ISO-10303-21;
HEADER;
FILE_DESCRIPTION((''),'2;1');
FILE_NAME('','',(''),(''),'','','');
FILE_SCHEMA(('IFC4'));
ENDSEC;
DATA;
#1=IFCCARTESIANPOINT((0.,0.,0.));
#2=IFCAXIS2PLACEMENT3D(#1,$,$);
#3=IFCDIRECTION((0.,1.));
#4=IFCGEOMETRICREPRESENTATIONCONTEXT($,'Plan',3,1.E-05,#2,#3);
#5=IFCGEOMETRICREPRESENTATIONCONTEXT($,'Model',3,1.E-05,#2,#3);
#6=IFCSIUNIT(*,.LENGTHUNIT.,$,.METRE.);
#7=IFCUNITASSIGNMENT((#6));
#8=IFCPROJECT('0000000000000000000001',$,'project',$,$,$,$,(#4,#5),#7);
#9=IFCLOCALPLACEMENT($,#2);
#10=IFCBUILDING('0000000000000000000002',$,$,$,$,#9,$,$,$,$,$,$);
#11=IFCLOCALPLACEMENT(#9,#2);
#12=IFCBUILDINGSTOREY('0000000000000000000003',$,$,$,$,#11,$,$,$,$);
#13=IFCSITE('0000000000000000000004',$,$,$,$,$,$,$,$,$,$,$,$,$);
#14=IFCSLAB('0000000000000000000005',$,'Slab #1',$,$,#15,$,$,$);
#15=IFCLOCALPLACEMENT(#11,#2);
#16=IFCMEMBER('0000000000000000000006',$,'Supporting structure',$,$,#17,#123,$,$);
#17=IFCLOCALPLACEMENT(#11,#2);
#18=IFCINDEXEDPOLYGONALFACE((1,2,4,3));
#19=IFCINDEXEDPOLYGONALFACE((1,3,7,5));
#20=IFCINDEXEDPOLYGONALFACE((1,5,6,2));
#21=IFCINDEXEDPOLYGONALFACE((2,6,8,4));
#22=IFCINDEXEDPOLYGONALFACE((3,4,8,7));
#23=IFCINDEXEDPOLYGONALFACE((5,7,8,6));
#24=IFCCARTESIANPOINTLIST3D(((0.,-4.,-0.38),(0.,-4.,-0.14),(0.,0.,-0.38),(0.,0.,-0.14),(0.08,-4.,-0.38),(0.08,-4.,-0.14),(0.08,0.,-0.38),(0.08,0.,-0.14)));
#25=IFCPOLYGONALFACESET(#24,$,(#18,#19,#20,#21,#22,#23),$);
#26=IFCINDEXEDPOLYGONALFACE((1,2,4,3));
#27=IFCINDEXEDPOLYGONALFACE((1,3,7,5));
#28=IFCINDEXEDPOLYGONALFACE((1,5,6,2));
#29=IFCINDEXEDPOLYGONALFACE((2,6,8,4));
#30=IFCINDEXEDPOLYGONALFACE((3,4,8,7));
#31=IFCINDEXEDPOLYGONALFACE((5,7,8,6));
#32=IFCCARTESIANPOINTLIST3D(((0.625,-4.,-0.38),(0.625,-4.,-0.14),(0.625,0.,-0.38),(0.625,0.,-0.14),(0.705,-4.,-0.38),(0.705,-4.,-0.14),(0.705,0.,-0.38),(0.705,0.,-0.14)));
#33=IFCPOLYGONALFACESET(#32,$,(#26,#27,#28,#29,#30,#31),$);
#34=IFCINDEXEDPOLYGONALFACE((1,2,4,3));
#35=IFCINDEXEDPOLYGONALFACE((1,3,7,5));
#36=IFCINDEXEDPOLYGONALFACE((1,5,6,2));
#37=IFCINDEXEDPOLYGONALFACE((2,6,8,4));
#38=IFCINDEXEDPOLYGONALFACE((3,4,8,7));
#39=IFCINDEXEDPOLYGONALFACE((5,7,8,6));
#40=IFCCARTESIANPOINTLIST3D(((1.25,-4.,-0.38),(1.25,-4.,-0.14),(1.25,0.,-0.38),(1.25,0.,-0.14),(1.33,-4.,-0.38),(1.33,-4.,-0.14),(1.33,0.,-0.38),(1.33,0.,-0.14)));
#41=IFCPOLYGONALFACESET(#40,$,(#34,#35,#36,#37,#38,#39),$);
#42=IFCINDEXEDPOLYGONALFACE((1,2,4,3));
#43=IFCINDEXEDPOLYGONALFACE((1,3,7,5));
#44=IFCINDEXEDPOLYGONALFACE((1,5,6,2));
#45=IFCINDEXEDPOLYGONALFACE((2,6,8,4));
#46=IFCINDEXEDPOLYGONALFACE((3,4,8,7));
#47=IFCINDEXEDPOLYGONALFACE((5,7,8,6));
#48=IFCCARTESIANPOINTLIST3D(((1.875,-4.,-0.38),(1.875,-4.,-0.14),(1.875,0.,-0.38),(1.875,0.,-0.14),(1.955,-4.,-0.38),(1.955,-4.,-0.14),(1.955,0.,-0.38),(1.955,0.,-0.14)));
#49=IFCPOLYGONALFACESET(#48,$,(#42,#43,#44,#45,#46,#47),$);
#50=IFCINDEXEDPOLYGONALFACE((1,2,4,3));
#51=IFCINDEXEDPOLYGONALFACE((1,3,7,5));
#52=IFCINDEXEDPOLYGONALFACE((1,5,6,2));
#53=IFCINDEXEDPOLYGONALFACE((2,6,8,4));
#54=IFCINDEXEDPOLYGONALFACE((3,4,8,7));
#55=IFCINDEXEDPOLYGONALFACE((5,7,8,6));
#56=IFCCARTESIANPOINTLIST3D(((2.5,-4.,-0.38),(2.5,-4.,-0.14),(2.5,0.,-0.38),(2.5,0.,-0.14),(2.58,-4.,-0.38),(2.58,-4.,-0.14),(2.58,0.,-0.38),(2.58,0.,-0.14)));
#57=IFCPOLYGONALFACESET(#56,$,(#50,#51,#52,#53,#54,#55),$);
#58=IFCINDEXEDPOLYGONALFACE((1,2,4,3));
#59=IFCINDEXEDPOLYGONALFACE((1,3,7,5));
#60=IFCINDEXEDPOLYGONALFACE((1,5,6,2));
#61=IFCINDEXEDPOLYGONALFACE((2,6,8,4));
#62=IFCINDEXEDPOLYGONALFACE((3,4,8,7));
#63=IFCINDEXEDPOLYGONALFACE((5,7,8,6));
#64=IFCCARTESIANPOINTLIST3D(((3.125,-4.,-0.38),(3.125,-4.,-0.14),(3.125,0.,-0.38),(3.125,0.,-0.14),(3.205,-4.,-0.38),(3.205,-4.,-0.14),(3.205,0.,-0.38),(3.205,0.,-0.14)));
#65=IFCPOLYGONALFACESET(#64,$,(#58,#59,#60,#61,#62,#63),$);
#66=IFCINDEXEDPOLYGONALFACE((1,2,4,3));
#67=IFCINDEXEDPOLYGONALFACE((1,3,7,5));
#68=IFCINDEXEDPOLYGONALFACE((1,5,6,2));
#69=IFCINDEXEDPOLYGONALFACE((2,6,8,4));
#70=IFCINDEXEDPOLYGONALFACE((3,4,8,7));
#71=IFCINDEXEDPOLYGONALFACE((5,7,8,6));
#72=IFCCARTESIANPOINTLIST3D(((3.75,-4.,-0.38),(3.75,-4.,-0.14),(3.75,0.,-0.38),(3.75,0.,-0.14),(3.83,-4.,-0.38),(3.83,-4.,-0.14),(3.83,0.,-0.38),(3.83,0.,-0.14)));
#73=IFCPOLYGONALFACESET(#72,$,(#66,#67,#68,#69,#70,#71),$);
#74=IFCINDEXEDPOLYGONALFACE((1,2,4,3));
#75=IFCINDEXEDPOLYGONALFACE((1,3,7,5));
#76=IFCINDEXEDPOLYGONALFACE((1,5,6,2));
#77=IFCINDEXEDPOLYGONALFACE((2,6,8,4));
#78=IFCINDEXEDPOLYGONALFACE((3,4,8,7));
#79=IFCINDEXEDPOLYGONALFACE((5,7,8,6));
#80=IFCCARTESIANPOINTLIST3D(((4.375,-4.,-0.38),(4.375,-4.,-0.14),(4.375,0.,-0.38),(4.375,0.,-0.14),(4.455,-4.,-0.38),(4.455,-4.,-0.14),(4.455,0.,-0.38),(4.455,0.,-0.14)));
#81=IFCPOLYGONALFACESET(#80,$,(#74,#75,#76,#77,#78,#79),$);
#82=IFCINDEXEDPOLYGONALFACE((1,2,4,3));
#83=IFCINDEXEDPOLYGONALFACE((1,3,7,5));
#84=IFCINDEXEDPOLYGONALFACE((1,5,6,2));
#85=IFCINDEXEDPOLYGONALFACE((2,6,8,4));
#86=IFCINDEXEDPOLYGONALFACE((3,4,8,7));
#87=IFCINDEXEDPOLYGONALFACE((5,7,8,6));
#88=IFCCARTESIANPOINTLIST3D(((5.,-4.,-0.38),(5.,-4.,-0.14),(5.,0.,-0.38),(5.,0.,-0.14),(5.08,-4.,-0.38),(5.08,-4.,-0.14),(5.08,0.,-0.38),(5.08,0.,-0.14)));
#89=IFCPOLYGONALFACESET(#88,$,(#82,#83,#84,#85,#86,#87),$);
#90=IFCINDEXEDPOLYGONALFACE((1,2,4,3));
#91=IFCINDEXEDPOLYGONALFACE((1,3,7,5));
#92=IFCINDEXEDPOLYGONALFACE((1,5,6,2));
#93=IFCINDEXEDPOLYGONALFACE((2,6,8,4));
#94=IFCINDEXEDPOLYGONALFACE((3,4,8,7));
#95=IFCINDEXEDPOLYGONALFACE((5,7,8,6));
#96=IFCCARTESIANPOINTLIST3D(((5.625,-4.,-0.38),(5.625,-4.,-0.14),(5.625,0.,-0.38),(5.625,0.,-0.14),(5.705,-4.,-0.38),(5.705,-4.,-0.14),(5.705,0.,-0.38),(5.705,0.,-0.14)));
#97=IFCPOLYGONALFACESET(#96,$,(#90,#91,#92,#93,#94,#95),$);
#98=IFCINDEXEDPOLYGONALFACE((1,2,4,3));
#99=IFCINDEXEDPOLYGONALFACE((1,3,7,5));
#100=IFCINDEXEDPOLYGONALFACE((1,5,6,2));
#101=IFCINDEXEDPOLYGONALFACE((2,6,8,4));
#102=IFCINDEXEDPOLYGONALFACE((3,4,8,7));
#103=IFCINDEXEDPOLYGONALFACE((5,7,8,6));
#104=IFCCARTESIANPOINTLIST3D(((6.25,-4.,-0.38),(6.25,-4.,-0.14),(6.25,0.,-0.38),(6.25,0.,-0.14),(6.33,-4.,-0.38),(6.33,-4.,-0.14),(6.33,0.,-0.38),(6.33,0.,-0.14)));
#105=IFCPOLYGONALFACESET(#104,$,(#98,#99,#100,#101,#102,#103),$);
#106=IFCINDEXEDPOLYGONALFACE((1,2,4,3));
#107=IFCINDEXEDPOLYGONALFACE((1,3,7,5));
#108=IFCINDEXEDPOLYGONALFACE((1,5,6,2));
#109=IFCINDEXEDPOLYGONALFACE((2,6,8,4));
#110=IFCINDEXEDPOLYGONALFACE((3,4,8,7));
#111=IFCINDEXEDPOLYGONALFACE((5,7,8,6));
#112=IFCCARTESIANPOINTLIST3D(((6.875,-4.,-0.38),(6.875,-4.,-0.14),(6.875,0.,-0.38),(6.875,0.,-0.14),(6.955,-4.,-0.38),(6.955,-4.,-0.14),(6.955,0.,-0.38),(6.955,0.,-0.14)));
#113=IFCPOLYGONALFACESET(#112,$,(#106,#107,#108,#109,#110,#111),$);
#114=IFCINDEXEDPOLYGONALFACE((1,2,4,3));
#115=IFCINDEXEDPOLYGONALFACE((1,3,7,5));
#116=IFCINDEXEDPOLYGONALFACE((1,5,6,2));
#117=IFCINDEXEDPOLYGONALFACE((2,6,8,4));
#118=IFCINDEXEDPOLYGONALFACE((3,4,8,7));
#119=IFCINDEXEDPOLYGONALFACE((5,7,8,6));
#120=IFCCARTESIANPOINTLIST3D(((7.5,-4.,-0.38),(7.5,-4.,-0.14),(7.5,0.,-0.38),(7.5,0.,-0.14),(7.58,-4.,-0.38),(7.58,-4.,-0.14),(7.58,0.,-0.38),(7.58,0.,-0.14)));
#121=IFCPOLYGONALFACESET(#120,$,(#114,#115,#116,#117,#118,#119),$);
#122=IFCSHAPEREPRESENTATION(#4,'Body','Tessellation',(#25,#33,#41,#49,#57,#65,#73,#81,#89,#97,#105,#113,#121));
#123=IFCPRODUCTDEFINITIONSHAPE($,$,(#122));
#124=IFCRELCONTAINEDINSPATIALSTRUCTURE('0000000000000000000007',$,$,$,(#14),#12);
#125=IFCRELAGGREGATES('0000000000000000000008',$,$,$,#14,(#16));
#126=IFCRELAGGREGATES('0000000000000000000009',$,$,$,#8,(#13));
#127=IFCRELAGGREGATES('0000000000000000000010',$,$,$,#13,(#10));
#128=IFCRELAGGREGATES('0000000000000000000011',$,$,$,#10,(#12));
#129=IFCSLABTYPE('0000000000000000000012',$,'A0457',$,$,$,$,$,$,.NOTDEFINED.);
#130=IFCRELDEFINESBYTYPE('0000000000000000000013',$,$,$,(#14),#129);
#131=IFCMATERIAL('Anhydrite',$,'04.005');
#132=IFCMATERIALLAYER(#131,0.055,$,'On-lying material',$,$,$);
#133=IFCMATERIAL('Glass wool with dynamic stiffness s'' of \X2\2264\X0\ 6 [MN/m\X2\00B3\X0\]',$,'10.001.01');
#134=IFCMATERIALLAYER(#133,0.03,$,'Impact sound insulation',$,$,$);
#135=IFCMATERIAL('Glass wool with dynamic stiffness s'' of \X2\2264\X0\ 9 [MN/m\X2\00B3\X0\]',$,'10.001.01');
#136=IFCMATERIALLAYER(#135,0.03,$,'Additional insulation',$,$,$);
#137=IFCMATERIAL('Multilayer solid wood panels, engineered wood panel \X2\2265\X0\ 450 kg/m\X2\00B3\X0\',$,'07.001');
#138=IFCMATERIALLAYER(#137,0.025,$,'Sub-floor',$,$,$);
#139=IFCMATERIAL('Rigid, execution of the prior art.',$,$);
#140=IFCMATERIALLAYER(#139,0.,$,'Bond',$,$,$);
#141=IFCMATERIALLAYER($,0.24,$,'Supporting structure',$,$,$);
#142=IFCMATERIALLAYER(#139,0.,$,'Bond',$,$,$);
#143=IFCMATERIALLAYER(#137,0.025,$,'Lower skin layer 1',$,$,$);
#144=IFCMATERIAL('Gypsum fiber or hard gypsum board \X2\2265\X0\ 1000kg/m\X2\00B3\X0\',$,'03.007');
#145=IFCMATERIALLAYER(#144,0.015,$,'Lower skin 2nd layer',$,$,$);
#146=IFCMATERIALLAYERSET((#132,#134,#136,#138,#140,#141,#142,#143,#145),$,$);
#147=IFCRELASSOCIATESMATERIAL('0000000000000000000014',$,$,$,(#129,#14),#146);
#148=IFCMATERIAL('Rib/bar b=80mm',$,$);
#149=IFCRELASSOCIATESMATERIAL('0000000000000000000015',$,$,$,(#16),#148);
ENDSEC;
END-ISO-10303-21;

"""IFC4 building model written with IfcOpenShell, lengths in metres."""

from ifc_helpers import new_model, si_unit, direction, frame, frame_2d, origin, place, context, project, spatial, rectangle, extrude, material, layer, layer_set, type_object, element, aggregate, save


model = new_model("IFC4")

# Units and contexts
plan_context = context("Plan", 3, precision=1e-05, world=origin(), true_north=direction((0.0, 1.0)))
model_context = context("Model", 3, precision=1e-05, world=origin(), true_north=direction((0.0, 1.0)))
ifc_project = project(units=[si_unit("LENGTHUNIT", "METRE")], contexts=[plan_context, model_context])

# Site, building, storey
site = spatial("IfcSite", under=ifc_project)
building_placement = place(None, origin())
building = spatial("IfcBuilding", under=site, at=building_placement)
storey_placement = place(building_placement, origin())
storey = spatial("IfcBuildingStorey", under=building, at=storey_placement)

# Slab, member
ifc_material_1 = material(Name="Anhydrite", Category="04.005")
ifc_layer_1 = layer(ifc_material_1, 0.055, Name="On-lying material")
ifc_material_2 = material(Name="Glass wool with dynamic stiffness s' of ≤ 6 [MN/m³]", Category="10.001.01")
ifc_layer_2 = layer(ifc_material_2, 0.03, Name="Impact sound insulation")
ifc_material_3 = material(Name="Glass wool with dynamic stiffness s' of ≤ 9 [MN/m³]", Category="10.001.01")
ifc_layer_3 = layer(ifc_material_3, 0.03, Name="Additional insulation")
ifc_material_4 = material(Name="Multilayer solid wood panels, engineered wood panel ≥ 450 kg/m³", Category="07.001")
ifc_layer_4 = layer(ifc_material_4, 0.025, Name="Sub-floor")
ifc_material_5 = material(Name="Rigid, execution of the prior art.")
ifc_layer_5 = layer(ifc_material_5, 0.0, Name="Bond")
ifc_layer_6 = layer(None, 0.24, Name="Supporting structure")
ifc_layer_7 = layer(ifc_material_5, 0.0, Name="Bond")
ifc_layer_8 = layer(ifc_material_4, 0.025, Name="Lower skin layer 1")
ifc_material_6 = material(Name="Gypsum fiber or hard gypsum board ≥ 1000kg/m³", Category="03.007")
ifc_layer_9 = layer(ifc_material_6, 0.015, Name="Lower skin 2nd layer")
ifc_layer_set = layer_set([ifc_layer_1, ifc_layer_2, ifc_layer_3, ifc_layer_4, ifc_layer_5, ifc_layer_6, ifc_layer_7, ifc_layer_8, ifc_layer_9])
slab_type = type_object("IfcSlabType", Name="A0457", PredefinedType="NOTDEFINED", material=ifc_layer_set)
slab_placement = place(None, frame((0.0, 0.0, 0.0), z_axis=(0.0, 0.0, -1.0), x_axis=(1.0, 0.0, 0.0)))
slab = element("IfcSlab", 1, at=slab_placement, inside=storey, type_object=slab_type, material=ifc_layer_set, Name="Slab #1")
ifc_material_7 = material(Name="Rib/bar b=80mm")
member_1_placement = place(slab_placement, origin())
member_1 = element("IfcMember", 2, at=member_1_placement, material=ifc_material_7, Name="Supporting structure", context=plan_context, shape_type="SweptSolid", body=[
    extrude(rectangle(XDim=0.08, YDim=0.24, at=frame_2d((0.04, 0.12), x_axis=(1.0, 0.0))), frame((0.0, 4.0, 0.14), z_axis=(0.0, -1.0, 0.0), x_axis=(1.0, 0.0, 0.0)), (0.0, 0.0, 1.0), 4.0),
    extrude(rectangle(XDim=0.08, YDim=0.24, at=frame_2d((0.04, 0.12), x_axis=(1.0, 0.0))), frame((0.625, 4.0, 0.14), z_axis=(0.0, -1.0, 0.0), x_axis=(1.0, 0.0, 0.0)), (0.0, 0.0, 1.0), 4.0),
    extrude(rectangle(XDim=0.08, YDim=0.24, at=frame_2d((0.04, 0.12), x_axis=(1.0, 0.0))), frame((1.25, 4.0, 0.14), z_axis=(0.0, -1.0, 0.0), x_axis=(1.0, 0.0, 0.0)), (0.0, 0.0, 1.0), 4.0),
    extrude(rectangle(XDim=0.08, YDim=0.24, at=frame_2d((0.04, 0.12), x_axis=(1.0, 0.0))), frame((1.875, 4.0, 0.14), z_axis=(0.0, -1.0, 0.0), x_axis=(1.0, 0.0, 0.0)), (0.0, 0.0, 1.0), 4.0),
    extrude(rectangle(XDim=0.08, YDim=0.24, at=frame_2d((0.04, 0.12), x_axis=(1.0, 0.0))), frame((2.5, 4.0, 0.14), z_axis=(0.0, -1.0, 0.0), x_axis=(1.0, 0.0, 0.0)), (0.0, 0.0, 1.0), 4.0),
    extrude(rectangle(XDim=0.08, YDim=0.24, at=frame_2d((0.04, 0.12), x_axis=(1.0, 0.0))), frame((3.125, 4.0, 0.14), z_axis=(0.0, -1.0, 0.0), x_axis=(1.0, 0.0, 0.0)), (0.0, 0.0, 1.0), 4.0),
    extrude(rectangle(XDim=0.08, YDim=0.24, at=frame_2d((0.04, 0.12), x_axis=(1.0, 0.0))), frame((3.75, 4.0, 0.14), z_axis=(0.0, -1.0, 0.0), x_axis=(1.0, 0.0, 0.0)), (0.0, 0.0, 1.0), 4.0),
    extrude(rectangle(XDim=0.08, YDim=0.24, at=frame_2d((0.04, 0.12), x_axis=(1.0, 0.0))), frame((4.375, 4.0, 0.14), z_axis=(0.0, -1.0, 0.0), x_axis=(1.0, 0.0, 0.0)), (0.0, 0.0, 1.0), 4.0),
    extrude(rectangle(XDim=0.08, YDim=0.24, at=frame_2d((0.04, 0.12), x_axis=(1.0, 0.0))), frame((5.0, 4.0, 0.14), z_axis=(0.0, -1.0, 0.0), x_axis=(1.0, 0.0, 0.0)), (0.0, 0.0, 1.0), 4.0),
    extrude(rectangle(XDim=0.08, YDim=0.24, at=frame_2d((0.04, 0.12), x_axis=(1.0, 0.0))), frame((5.625, 4.0, 0.14), z_axis=(0.0, -1.0, 0.0), x_axis=(1.0, 0.0, 0.0)), (0.0, 0.0, 1.0), 4.0),
    extrude(rectangle(XDim=0.08, YDim=0.24, at=frame_2d((0.04, 0.12), x_axis=(1.0, 0.0))), frame((6.25, 4.0, 0.14), z_axis=(0.0, -1.0, 0.0), x_axis=(1.0, 0.0, 0.0)), (0.0, 0.0, 1.0), 4.0),
    extrude(rectangle(XDim=0.08, YDim=0.24, at=frame_2d((0.04, 0.12), x_axis=(1.0, 0.0))), frame((6.875, 4.0, 0.14), z_axis=(0.0, -1.0, 0.0), x_axis=(1.0, 0.0, 0.0)), (0.0, 0.0, 1.0), 4.0),
    extrude(rectangle(XDim=0.08, YDim=0.24, at=frame_2d((0.04, 0.12), x_axis=(1.0, 0.0))), frame((7.5, 4.0, 0.14), z_axis=(0.0, -1.0, 0.0), x_axis=(1.0, 0.0, 0.0)), (0.0, 0.0, 1.0), 4.0),
])
aggregate(slab, [member_1])

save(model, "model.ifc")
